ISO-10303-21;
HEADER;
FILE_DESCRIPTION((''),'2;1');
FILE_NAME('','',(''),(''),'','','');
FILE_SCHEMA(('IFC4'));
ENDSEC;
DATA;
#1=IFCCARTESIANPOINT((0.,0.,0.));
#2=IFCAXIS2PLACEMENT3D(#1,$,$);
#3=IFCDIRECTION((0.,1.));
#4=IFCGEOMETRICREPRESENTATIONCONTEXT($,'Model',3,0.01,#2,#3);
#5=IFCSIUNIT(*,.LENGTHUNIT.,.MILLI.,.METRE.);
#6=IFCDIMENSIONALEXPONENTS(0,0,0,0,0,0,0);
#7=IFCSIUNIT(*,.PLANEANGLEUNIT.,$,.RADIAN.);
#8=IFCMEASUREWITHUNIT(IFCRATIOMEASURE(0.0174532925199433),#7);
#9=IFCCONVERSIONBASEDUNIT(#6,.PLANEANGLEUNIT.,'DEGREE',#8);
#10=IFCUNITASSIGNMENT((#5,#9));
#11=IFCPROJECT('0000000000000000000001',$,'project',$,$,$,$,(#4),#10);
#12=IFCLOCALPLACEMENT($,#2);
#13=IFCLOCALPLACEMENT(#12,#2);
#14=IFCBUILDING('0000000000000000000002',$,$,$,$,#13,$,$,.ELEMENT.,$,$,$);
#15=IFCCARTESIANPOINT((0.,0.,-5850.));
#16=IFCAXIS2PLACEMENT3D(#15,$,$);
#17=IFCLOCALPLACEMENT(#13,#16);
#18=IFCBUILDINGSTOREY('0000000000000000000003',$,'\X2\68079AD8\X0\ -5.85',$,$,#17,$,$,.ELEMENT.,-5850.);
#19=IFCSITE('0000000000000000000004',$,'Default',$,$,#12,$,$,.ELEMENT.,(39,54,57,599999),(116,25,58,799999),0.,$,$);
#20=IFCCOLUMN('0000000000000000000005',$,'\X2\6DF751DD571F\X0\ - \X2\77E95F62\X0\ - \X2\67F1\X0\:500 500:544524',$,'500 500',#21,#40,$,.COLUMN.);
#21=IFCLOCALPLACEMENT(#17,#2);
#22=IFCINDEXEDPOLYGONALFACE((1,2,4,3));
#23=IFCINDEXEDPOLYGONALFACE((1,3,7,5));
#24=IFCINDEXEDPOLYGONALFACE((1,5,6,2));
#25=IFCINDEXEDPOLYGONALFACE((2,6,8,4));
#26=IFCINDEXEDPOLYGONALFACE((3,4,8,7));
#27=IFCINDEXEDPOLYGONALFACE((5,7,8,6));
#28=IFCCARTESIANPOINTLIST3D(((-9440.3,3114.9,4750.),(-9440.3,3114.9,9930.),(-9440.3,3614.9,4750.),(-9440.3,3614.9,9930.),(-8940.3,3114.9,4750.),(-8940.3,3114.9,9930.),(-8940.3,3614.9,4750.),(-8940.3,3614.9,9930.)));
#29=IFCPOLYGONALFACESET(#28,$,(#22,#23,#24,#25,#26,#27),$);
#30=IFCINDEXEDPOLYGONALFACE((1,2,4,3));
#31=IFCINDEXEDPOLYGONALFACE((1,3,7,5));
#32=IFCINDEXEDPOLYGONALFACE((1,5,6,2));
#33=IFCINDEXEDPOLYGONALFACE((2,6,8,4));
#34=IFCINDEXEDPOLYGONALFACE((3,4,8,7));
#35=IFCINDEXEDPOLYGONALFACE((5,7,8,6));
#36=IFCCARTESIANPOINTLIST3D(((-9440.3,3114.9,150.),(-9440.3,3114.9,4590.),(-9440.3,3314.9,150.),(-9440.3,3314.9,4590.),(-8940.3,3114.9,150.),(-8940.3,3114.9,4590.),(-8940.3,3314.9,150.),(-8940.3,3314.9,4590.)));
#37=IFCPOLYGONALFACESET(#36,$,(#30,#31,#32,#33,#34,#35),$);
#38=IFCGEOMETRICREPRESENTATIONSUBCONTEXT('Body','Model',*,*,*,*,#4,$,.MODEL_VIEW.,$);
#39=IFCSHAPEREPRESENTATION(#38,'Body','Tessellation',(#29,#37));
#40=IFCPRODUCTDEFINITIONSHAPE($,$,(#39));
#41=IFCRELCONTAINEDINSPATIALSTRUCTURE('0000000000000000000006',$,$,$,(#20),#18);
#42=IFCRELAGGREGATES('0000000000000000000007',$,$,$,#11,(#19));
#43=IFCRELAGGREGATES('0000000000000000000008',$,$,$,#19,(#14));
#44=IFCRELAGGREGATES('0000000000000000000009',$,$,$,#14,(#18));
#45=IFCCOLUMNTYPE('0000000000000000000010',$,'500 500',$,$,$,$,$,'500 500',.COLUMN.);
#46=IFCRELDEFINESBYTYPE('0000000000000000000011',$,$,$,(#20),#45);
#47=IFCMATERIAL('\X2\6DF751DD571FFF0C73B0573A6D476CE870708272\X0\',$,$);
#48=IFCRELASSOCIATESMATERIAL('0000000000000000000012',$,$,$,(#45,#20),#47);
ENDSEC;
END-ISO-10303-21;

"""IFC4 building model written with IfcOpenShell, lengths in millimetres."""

from ifc_helpers import new_model, entity, si_unit, converted_unit, direction, frame, frame_2d, origin, place, context, subcontext, project, spatial, rectangle, extrude, source, transform, mapped, material, type_object, type_shapes, element, save


model = new_model("IFC4")

# Units and contexts
model_context = context("Model", 3, precision=0.01, world=origin(), true_north=direction((0.0, 1.0)))
body_context = subcontext(model_context, "Body", "Model", "MODEL_VIEW")
ifc_project = project(units=[si_unit("LENGTHUNIT", "METRE", prefix="MILLI"), converted_unit("PLANEANGLEUNIT", "DEGREE", entity("IfcRatioMeasure", 0.0174532925199433), si_unit("PLANEANGLEUNIT", "RADIAN"), dimensions=[0, 0, 0, 0, 0, 0, 0])], contexts=[model_context])

# Site, building, storey
site_placement = place(None, origin())
site = spatial("IfcSite", under=ifc_project, at=site_placement, Name="Default", CompositionType="ELEMENT", RefLatitude=(39, 54, 57, 599999), RefLongitude=(116, 25, 58, 799999), RefElevation=0.0)
building_placement = place(site_placement, origin())
building = spatial("IfcBuilding", under=site, at=building_placement, CompositionType="ELEMENT")
storey_placement = place(building_placement, frame((0.0, 0.0, -5850.0)))
storey = spatial("IfcBuildingStorey", under=building, at=storey_placement, Name="标高 -5.85", CompositionType="ELEMENT", Elevation=-5850.0)

# Column
ifc_material = material(Name="混凝土，现场浇注灰色")
column_type = type_object("IfcColumnType", Name="500 500", ElementType="500 500", PredefinedType="COLUMN", material=ifc_material)
shared_shape = source(origin(), body_context, "Body", "SweptSolid", [
    extrude(rectangle(XDim=500.0, YDim=500.0, at=frame_2d((0.0, 0.0), x_axis=(1.0, 0.0))), frame((-9190.3, 3364.9, -1100.0), z_axis=(0.0, 0.0, 1.0), x_axis=(0.0, -1.0, 0.0)), (0.0, 0.0, 1.0), 5180.0),
    extrude(rectangle(XDim=200.0, YDim=500.0, at=frame_2d((0.0, 0.0), x_axis=(1.0, 0.0))), frame((-9190.3, 3214.9, -5700.0), z_axis=(0.0, 0.0, 1.0), x_axis=(0.0, -1.0, 0.0)), (0.0, 0.0, 1.0), 4440.0),
])
type_shapes(column_type, [shared_shape])
column_placement = place(storey_placement, frame((0.0, 0.0, 5850.0)))
element("IfcColumn", 1, at=column_placement, inside=storey, type_object=column_type, material=ifc_material, Name="混凝土 - 矩形 - 柱:500 500:544524", ObjectType="500 500", PredefinedType="COLUMN", context=body_context, shape_type="MappedRepresentation", body=[
    mapped(shared_shape, transform((0.0, 0.0, 0.0), scale=1.0)),
])

save(model, "model.ifc")
